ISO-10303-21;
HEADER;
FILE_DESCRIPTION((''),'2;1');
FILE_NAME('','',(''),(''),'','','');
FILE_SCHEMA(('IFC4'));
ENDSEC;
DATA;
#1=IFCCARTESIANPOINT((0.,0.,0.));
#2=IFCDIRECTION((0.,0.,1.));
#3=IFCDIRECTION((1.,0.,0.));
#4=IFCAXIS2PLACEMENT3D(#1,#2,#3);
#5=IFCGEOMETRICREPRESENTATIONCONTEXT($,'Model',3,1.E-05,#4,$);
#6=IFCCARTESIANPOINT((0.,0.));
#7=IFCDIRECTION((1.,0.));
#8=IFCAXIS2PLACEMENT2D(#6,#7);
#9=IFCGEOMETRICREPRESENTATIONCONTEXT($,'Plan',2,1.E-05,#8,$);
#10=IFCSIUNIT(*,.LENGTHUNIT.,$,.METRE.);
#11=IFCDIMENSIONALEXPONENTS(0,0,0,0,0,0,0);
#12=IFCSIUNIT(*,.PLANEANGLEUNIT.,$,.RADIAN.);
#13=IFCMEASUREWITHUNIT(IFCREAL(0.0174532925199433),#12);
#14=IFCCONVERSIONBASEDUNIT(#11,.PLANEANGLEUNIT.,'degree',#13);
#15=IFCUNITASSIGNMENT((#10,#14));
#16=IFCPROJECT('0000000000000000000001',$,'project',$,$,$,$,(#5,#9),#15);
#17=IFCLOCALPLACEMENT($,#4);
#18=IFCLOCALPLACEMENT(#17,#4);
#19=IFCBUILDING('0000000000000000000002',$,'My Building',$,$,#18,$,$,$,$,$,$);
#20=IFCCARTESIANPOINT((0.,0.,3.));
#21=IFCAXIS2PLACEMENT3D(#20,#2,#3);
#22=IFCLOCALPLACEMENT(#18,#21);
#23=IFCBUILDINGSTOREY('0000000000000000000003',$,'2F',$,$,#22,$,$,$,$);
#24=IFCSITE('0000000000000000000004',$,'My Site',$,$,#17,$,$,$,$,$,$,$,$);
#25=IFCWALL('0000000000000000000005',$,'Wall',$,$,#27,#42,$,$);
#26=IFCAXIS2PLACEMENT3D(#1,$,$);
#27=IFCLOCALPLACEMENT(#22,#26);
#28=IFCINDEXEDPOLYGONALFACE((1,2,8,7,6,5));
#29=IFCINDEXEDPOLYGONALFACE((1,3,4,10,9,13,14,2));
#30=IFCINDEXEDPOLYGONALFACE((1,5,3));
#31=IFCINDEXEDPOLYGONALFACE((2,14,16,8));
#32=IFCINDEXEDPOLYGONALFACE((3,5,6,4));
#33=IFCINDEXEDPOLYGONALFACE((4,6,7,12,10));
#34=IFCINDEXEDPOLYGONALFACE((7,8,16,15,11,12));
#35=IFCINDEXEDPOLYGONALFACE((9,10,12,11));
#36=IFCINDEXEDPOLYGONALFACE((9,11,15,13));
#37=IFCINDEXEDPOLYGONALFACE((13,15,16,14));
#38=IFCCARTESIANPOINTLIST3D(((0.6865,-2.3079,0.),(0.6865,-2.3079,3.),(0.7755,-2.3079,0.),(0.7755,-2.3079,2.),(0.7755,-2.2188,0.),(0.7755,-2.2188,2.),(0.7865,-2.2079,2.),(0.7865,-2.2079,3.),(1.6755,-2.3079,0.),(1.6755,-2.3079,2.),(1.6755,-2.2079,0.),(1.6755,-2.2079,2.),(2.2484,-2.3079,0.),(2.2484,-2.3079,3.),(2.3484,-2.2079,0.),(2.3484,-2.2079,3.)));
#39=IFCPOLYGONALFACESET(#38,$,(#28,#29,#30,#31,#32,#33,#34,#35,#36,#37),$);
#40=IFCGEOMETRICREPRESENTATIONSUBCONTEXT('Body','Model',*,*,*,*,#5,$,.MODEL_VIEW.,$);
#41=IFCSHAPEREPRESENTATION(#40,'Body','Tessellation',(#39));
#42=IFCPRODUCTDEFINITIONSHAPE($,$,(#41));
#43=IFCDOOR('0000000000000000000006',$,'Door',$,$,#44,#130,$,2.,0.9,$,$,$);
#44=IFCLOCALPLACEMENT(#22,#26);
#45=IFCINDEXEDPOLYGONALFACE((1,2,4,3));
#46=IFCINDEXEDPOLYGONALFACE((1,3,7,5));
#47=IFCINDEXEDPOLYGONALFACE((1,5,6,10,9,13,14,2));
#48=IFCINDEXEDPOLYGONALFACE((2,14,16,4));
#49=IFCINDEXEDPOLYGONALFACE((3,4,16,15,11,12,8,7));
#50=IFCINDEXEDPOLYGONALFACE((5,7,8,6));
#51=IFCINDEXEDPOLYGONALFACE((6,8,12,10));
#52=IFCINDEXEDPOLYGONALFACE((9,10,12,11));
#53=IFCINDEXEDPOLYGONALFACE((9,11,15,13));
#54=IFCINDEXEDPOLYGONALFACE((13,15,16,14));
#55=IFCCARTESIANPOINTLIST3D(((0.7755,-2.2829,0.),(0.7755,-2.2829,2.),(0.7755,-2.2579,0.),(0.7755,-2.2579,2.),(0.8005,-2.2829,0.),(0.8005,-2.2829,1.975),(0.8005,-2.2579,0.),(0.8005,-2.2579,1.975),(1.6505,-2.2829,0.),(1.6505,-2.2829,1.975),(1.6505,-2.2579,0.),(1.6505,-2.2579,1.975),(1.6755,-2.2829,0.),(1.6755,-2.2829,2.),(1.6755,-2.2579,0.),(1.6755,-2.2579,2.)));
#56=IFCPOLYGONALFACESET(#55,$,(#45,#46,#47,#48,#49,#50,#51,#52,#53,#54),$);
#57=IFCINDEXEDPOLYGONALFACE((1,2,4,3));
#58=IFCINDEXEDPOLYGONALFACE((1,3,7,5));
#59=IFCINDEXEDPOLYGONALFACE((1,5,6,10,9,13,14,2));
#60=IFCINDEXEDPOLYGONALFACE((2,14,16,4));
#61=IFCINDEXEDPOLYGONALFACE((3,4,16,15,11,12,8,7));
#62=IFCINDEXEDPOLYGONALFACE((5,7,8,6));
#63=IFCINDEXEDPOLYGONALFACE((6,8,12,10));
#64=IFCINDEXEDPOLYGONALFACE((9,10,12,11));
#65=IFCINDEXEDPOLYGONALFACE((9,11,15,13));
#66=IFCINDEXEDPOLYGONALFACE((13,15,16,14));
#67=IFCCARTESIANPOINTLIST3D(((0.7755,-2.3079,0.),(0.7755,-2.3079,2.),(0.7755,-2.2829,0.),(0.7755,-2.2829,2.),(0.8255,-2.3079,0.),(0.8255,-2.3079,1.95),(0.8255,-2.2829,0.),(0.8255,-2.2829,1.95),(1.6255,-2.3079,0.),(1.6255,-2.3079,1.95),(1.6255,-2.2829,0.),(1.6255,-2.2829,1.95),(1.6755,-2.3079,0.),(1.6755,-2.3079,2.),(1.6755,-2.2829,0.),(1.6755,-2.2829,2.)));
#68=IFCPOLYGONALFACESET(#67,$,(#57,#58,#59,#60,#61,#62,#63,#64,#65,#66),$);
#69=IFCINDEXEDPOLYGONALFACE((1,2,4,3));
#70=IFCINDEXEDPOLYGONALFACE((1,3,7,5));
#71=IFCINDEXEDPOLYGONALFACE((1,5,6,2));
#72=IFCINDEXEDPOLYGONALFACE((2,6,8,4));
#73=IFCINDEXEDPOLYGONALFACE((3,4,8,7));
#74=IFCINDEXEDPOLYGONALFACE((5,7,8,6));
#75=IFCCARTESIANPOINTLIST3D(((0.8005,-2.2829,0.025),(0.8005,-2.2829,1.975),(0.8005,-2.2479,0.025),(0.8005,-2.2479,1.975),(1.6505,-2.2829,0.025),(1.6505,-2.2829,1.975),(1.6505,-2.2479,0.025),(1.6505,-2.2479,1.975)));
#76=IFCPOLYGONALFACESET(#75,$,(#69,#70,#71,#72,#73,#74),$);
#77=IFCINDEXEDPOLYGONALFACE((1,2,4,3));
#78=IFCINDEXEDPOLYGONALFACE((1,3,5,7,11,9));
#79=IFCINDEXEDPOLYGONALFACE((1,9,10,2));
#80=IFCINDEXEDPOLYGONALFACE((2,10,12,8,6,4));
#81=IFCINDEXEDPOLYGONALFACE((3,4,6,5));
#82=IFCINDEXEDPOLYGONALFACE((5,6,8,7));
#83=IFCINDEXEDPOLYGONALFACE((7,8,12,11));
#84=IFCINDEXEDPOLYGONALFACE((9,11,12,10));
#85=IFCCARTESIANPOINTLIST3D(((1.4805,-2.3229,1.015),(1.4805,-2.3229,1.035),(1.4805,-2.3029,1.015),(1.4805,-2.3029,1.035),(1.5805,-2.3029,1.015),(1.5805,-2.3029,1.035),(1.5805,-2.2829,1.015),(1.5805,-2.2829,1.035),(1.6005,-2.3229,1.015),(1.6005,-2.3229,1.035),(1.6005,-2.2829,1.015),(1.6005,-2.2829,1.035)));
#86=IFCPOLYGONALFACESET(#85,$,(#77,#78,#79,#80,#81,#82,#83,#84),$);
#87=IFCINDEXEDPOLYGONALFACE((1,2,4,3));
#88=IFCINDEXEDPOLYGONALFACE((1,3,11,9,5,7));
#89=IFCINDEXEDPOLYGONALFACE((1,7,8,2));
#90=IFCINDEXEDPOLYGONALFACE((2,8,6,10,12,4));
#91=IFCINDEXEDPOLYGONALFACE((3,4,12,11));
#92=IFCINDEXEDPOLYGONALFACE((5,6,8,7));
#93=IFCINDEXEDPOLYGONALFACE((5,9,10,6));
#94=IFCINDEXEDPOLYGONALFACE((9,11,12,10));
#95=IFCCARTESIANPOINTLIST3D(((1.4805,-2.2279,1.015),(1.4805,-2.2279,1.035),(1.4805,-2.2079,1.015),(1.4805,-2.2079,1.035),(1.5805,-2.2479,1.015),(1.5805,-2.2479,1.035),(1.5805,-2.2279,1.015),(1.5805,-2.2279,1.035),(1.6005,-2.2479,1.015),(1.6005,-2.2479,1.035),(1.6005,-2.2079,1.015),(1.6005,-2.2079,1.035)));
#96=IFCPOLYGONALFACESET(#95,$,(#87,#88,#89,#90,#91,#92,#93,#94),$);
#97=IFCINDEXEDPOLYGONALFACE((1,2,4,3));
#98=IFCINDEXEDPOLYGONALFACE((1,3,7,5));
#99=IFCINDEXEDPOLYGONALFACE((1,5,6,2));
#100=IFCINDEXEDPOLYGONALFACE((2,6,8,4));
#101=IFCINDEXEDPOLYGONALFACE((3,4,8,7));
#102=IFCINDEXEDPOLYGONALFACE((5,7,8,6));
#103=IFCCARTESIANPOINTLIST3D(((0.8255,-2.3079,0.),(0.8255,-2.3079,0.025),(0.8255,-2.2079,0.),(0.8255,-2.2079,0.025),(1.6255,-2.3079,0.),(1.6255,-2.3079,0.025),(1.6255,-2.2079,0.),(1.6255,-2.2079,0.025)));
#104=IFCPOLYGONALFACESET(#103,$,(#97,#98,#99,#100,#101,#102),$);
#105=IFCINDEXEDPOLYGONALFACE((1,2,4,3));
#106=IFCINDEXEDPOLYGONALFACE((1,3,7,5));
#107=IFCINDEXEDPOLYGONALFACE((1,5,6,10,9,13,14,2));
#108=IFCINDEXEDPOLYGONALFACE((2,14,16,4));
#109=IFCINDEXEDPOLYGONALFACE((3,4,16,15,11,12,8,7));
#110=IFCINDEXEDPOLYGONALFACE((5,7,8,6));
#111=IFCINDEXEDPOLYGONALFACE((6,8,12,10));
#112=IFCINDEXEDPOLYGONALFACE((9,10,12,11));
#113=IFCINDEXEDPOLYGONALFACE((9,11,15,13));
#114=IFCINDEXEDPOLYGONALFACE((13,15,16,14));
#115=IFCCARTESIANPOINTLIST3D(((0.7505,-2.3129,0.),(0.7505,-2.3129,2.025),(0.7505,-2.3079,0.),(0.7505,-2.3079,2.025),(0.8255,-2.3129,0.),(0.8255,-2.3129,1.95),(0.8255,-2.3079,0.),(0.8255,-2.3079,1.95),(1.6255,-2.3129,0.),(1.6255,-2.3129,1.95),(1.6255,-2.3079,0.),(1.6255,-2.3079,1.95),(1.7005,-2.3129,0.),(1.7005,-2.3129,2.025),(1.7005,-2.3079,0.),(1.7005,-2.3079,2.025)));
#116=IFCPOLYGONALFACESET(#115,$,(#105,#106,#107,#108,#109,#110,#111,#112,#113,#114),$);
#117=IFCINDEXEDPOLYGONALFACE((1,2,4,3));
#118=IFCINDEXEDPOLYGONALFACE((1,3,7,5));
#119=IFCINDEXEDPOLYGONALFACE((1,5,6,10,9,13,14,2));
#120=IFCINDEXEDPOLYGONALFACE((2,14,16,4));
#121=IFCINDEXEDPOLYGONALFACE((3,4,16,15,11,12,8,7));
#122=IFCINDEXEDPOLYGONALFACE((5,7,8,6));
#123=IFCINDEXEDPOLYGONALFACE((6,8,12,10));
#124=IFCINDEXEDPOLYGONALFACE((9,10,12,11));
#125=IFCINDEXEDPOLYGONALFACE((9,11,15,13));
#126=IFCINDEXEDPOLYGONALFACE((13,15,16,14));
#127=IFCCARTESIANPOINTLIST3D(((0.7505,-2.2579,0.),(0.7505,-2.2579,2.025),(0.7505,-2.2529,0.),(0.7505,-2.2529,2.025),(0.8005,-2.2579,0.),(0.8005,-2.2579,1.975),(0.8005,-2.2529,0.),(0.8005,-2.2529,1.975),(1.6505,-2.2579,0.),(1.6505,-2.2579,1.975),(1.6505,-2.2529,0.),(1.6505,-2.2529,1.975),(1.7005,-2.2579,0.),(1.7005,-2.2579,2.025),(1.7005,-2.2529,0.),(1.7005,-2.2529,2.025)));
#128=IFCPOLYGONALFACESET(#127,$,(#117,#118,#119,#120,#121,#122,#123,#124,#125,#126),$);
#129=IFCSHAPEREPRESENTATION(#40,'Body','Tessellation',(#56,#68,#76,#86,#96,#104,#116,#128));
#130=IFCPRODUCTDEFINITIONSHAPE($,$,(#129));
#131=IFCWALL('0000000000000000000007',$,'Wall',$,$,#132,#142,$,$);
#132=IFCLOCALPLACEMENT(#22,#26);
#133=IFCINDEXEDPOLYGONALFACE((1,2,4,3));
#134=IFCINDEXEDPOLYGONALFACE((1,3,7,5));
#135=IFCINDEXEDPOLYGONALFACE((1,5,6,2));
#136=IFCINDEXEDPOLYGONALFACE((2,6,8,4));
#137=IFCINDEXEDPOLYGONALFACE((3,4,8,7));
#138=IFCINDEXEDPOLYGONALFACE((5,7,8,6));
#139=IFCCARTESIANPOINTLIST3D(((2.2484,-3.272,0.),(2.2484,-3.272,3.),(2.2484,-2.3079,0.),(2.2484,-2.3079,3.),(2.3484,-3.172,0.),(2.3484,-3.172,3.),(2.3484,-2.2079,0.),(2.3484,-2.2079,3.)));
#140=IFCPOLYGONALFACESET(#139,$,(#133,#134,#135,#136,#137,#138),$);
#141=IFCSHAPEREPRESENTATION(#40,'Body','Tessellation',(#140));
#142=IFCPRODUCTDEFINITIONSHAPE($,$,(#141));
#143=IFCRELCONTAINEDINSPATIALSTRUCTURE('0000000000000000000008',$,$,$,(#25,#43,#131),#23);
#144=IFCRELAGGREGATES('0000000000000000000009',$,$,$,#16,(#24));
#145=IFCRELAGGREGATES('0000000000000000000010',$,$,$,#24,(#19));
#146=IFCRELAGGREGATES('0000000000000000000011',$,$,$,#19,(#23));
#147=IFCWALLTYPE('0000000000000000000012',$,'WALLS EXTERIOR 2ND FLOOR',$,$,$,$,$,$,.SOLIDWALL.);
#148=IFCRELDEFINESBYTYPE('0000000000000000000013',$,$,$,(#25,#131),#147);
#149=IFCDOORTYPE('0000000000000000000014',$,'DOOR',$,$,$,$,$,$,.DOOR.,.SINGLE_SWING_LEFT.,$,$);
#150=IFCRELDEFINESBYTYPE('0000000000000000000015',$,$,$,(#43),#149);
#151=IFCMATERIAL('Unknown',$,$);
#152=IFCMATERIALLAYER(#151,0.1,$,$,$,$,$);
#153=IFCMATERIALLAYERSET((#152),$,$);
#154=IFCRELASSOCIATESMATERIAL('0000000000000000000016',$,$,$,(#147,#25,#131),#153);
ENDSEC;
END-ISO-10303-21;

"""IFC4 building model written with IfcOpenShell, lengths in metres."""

from ifc_helpers import new_model, entity, si_unit, converted_unit, frame, origin_with_axes, origin_2d_with_axis, place, context, subcontext, project, spatial, line, indexed_curve, outline, extrude, shape, source, transform, mapped, material, layer, layer_set, layer_usage, type_object, type_shapes, element, fill, save


model = new_model("IFC4")

# Units and contexts
model_context = context("Model", 3, precision=1e-05, world=origin_with_axes())
plan_context = context("Plan", 2, precision=1e-05, world=origin_2d_with_axis())
body_context_1 = subcontext(model_context, "Body", "Model", "MODEL_VIEW")
body_context_2 = subcontext(plan_context, "Body", "Plan", "PLAN_VIEW")
ifc_project = project(units=[si_unit("LENGTHUNIT", "METRE"), converted_unit("PLANEANGLEUNIT", "degree", entity("IfcReal", 0.0174532925199433), si_unit("PLANEANGLEUNIT", "RADIAN"), dimensions=[0, 0, 0, 0, 0, 0, 0])], contexts=[model_context, plan_context])

# Site, building, storey
site_placement = place(None, origin_with_axes())
site = spatial("IfcSite", under=ifc_project, at=site_placement, Name="My Site")
building_placement = place(site_placement, origin_with_axes())
building = spatial("IfcBuilding", under=site, at=building_placement, Name="My Building")
storey_placement = place(building_placement, frame((0.0, 0.0, 3.0), z_axis=(0.0, 0.0, 1.0), x_axis=(1.0, 0.0, 0.0)))
storey = spatial("IfcBuildingStorey", under=building, at=storey_placement, Name="2F")

# Shared definitions
ifc_material = material(Name="Unknown")

# Shared definitions
ifc_layer_1 = layer(ifc_material, 0.1)
ifc_layer_set_1 = layer_set([ifc_layer_1])
wall_type_1 = type_object("IfcWallType", Name="WALLS EXTERIOR 2ND FLOOR", PredefinedType="SOLIDWALL", material=ifc_layer_set_1)

# Wall, opening, door
ifc_layer_usage_1 = layer_usage(ifc_layer_set_1, "AXIS2", "POSITIVE", 0.0)
wall_1_placement = place(storey_placement, frame((0.6865, -2.3079, 0.0), z_axis=(0.0, 0.0, 1.0), x_axis=(1.0, 0.0, 0.0)))
wall_1 = element("IfcWall", 1, at=wall_1_placement, inside=storey, type_object=wall_type_1, material=ifc_layer_usage_1, Name="Wall", context=body_context_1, shape_type="SweptSolid", body=[
    extrude(outline(indexed_curve([(0.0, 0.0), (0.1, 0.1), (1.6619, 0.1), (1.5619, 0.0)], segments=[line(1, 2, 3, 4, 1)])), origin_with_axes(), (0.0, 0.0, 1.0), 3.0),
])
shared_shape_1 = source(origin_with_axes(), body_context_1, "Body", "SweptSolid", [
    extrude(outline(indexed_curve([(0.0, 0.0), (0.9, 0.0), (0.9, 2.0), (0.0, 2.0)], segments=[line(1, 2, 3, 4, 1)])), frame((0.0, -0.6, 0.0), z_axis=(0.0, -1.0, 0.0), x_axis=(1.0, 0.0, 0.0)), (0.0, 0.0, -1.0), 1.2),
])
opening_1_placement = place(wall_1_placement, frame((0.089, 0.0, 0.0), z_axis=(0.0, 0.0, 1.0), x_axis=(1.0, 0.0, 0.0)))
opening_1 = element("IfcOpeningElement", 2, at=opening_1_placement, cuts=wall_1, PredefinedType="OPENING", context=body_context_1, shape_type="MappedRepresentation", body=[
    mapped(shared_shape_1, transform((0.0, 0.0, 0.0), x_axis=(1.0, 0.0, 0.0), y_axis=(0.0, 1.0, 0.0), z_axis=(0.0, 0.0, 1.0), scale=1.0)),
])
door_type = type_object("IfcDoorType", Name="DOOR", OperationType="SINGLE_SWING_LEFT", PredefinedType="DOOR")
shared_shape_2 = source(origin_with_axes(), body_context_1, "Body", "SweptSolid", [
    extrude(outline(indexed_curve([(0.0, 0.0), (0.0, 2.0), (0.9, 2.0), (0.9, 0.0), (0.875, 0.0), (0.875, 1.975), (0.025, 1.975), (0.025, 0.0)], segments=[line(1, 2, 3, 4, 5, 6, 7, 8, 1)])), frame((0.0, 0.025, 0.0), z_axis=(0.0, -1.0, 0.0), x_axis=(1.0, 0.0, 0.0)), (0.0, 0.0, -1.0), 0.025),
    extrude(outline(indexed_curve([(0.0, 0.0), (0.0, 2.0), (0.9, 2.0), (0.9, 0.0), (0.85, 0.0), (0.85, 1.95), (0.05, 1.95), (0.05, 0.0)], segments=[line(1, 2, 3, 4, 5, 6, 7, 8, 1)])), frame((0.0, 0.0, 0.0), z_axis=(0.0, -1.0, 0.0), x_axis=(1.0, 0.0, 0.0)), (0.0, 0.0, -1.0), 0.025),
    extrude(outline(indexed_curve([(0.0, 0.0), (0.85, 0.0), (0.85, 0.035), (0.0, 0.035)], segments=[line(1, 2, 3, 4, 1)])), frame((0.025, 0.025, 0.025), z_axis=(0.0, 0.0, 1.0), x_axis=(1.0, 0.0, 0.0)), (0.0, 0.0, 1.0), 1.95),
    extrude(outline(indexed_curve([(0.0, 0.0), (0.0, -0.04), (-0.12, -0.04), (-0.12, -0.02), (-0.02, -0.02), (-0.02, 0.0)], segments=[line(1, 2, 3, 4, 5, 6, 1)])), frame((0.825, 0.025, 1.015), z_axis=(0.0, 0.0, 1.0), x_axis=(1.0, 0.0, 0.0)), (0.0, 0.0, 1.0), 0.02),
    extrude(outline(indexed_curve([(0.0, 0.0), (0.0, 0.04), (-0.12, 0.04), (-0.12, 0.02), (-0.02, 0.02), (-0.02, 0.0)], segments=[line(1, 2, 3, 4, 5, 6, 1)])), frame((0.825, 0.06, 1.015), z_axis=(0.0, 0.0, 1.0), x_axis=(1.0, 0.0, 0.0)), (0.0, 0.0, 1.0), 0.02),
    extrude(outline(indexed_curve([(0.0, 0.0), (0.8, 0.0), (0.8, 0.1), (0.0, 0.1)], segments=[line(1, 2, 3, 4, 1)])), frame((0.05, 0.0, 0.0), z_axis=(0.0, 0.0, 1.0), x_axis=(1.0, 0.0, 0.0)), (0.0, 0.0, 1.0), 0.025),
    extrude(outline(indexed_curve([(0.0, 0.0), (0.0, 2.025), (0.95, 2.025), (0.95, 0.0), (0.875, 0.0), (0.875, 1.95), (0.075, 1.95), (0.075, 0.0)], segments=[line(1, 2, 3, 4, 5, 6, 7, 8, 1)])), frame((-0.025, -0.005, 0.0), z_axis=(0.0, -1.0, 0.0), x_axis=(1.0, 0.0, 0.0)), (0.0, 0.0, -1.0), 0.005),
    extrude(outline(indexed_curve([(0.0, 0.0), (0.0, 2.025), (0.95, 2.025), (0.95, 0.0), (0.9, 0.0), (0.9, 1.975), (0.05, 1.975), (0.05, 0.0)], segments=[line(1, 2, 3, 4, 5, 6, 7, 8, 1)])), frame((-0.025, 0.05, 0.0), z_axis=(0.0, -1.0, 0.0), x_axis=(1.0, 0.0, 0.0)), (0.0, 0.0, -1.0), 0.005),
])
shared_shape_3 = source(origin_with_axes(), body_context_2, "Body", "Curve2D", [
    entity("IfcIndexedPolyCurve", entity("IfcCartesianPointList2D", [[0.0, 0.0], [0.0, 0.05], [0.025, 0.05], [0.025, 0.025], [0.05, 0.025], [0.05, 0.0]]), [entity("IfcLineIndex", [1, 2, 3, 4, 5, 6, 1])]),
    entity("IfcIndexedPolyCurve", entity("IfcCartesianPointList2D", [[0.9, 0.0], [0.9, 0.05], [0.875, 0.05], [0.875, 0.025], [0.85, 0.025], [0.85, 0.0]]), [entity("IfcLineIndex", [1, 2, 3, 4, 5, 6, 1])]),
    entity("IfcTrimmedCurve", entity("IfcEllipse", entity("IfcAxis2Placement2D", entity("IfcCartesianPoint", [0.06, 0.05]), entity("IfcDirection", [1.0, 0.0])), 0.815, 0.85), [entity("IfcCartesianPoint", [0.875, 0.05])], [entity("IfcCartesianPoint", [0.06, 0.9])], True, "CARTESIAN"),
    entity("IfcIndexedPolyCurve", entity("IfcCartesianPointList2D", [[0.025, 0.05], [0.06, 0.05], [0.06, 0.9], [0.025, 0.9]]), [entity("IfcLineIndex", [1, 2, 3, 4, 1])]),
])
type_shapes(door_type, [shared_shape_2, shared_shape_3])
door_placement = place(opening_1_placement, origin_with_axes())
door = element("IfcDoor", 3, at=door_placement, inside=storey, type_object=door_type, Name="Door", OverallHeight=2.0, OverallWidth=0.9, shapes=[
    shape(body_context_1, "Body", "MappedRepresentation", [mapped(shared_shape_2, transform((0.0, 0.0, 0.0), x_axis=(1.0, 0.0, 0.0), y_axis=(0.0, 1.0, 0.0), z_axis=(0.0, 0.0, 1.0), scale=1.0))]),
    shape(body_context_2, "Body", "MappedRepresentation", [mapped(shared_shape_3, transform((0.0, 0.0, 0.0), x_axis=(1.0, 0.0, 0.0), y_axis=(0.0, 1.0, 0.0), z_axis=(0.0, 0.0, 1.0), scale=1.0))]),
])
fill(opening_1, door)

# Wall
ifc_layer_usage_2 = layer_usage(ifc_layer_set_1, "AXIS2", "POSITIVE", 0.0)
wall_2_placement = place(storey_placement, frame((2.2484, -2.3079, 0.0), z_axis=(0.0, 0.0, 1.0), x_axis=(0.0, -1.0, 0.0)))
element("IfcWall", 4, at=wall_2_placement, inside=storey, type_object=wall_type_1, material=ifc_layer_usage_2, Name="Wall", context=body_context_1, shape_type="SweptSolid", body=[
    extrude(outline(indexed_curve([(0.0, 0.0), (-0.1, 0.1), (0.8642, 0.1), (0.9642, 0.0)], segments=[line(1, 2, 3, 4, 1)])), origin_with_axes(), (0.0, 0.0, 1.0), 3.0),
])

save(model, "model.ifc")
